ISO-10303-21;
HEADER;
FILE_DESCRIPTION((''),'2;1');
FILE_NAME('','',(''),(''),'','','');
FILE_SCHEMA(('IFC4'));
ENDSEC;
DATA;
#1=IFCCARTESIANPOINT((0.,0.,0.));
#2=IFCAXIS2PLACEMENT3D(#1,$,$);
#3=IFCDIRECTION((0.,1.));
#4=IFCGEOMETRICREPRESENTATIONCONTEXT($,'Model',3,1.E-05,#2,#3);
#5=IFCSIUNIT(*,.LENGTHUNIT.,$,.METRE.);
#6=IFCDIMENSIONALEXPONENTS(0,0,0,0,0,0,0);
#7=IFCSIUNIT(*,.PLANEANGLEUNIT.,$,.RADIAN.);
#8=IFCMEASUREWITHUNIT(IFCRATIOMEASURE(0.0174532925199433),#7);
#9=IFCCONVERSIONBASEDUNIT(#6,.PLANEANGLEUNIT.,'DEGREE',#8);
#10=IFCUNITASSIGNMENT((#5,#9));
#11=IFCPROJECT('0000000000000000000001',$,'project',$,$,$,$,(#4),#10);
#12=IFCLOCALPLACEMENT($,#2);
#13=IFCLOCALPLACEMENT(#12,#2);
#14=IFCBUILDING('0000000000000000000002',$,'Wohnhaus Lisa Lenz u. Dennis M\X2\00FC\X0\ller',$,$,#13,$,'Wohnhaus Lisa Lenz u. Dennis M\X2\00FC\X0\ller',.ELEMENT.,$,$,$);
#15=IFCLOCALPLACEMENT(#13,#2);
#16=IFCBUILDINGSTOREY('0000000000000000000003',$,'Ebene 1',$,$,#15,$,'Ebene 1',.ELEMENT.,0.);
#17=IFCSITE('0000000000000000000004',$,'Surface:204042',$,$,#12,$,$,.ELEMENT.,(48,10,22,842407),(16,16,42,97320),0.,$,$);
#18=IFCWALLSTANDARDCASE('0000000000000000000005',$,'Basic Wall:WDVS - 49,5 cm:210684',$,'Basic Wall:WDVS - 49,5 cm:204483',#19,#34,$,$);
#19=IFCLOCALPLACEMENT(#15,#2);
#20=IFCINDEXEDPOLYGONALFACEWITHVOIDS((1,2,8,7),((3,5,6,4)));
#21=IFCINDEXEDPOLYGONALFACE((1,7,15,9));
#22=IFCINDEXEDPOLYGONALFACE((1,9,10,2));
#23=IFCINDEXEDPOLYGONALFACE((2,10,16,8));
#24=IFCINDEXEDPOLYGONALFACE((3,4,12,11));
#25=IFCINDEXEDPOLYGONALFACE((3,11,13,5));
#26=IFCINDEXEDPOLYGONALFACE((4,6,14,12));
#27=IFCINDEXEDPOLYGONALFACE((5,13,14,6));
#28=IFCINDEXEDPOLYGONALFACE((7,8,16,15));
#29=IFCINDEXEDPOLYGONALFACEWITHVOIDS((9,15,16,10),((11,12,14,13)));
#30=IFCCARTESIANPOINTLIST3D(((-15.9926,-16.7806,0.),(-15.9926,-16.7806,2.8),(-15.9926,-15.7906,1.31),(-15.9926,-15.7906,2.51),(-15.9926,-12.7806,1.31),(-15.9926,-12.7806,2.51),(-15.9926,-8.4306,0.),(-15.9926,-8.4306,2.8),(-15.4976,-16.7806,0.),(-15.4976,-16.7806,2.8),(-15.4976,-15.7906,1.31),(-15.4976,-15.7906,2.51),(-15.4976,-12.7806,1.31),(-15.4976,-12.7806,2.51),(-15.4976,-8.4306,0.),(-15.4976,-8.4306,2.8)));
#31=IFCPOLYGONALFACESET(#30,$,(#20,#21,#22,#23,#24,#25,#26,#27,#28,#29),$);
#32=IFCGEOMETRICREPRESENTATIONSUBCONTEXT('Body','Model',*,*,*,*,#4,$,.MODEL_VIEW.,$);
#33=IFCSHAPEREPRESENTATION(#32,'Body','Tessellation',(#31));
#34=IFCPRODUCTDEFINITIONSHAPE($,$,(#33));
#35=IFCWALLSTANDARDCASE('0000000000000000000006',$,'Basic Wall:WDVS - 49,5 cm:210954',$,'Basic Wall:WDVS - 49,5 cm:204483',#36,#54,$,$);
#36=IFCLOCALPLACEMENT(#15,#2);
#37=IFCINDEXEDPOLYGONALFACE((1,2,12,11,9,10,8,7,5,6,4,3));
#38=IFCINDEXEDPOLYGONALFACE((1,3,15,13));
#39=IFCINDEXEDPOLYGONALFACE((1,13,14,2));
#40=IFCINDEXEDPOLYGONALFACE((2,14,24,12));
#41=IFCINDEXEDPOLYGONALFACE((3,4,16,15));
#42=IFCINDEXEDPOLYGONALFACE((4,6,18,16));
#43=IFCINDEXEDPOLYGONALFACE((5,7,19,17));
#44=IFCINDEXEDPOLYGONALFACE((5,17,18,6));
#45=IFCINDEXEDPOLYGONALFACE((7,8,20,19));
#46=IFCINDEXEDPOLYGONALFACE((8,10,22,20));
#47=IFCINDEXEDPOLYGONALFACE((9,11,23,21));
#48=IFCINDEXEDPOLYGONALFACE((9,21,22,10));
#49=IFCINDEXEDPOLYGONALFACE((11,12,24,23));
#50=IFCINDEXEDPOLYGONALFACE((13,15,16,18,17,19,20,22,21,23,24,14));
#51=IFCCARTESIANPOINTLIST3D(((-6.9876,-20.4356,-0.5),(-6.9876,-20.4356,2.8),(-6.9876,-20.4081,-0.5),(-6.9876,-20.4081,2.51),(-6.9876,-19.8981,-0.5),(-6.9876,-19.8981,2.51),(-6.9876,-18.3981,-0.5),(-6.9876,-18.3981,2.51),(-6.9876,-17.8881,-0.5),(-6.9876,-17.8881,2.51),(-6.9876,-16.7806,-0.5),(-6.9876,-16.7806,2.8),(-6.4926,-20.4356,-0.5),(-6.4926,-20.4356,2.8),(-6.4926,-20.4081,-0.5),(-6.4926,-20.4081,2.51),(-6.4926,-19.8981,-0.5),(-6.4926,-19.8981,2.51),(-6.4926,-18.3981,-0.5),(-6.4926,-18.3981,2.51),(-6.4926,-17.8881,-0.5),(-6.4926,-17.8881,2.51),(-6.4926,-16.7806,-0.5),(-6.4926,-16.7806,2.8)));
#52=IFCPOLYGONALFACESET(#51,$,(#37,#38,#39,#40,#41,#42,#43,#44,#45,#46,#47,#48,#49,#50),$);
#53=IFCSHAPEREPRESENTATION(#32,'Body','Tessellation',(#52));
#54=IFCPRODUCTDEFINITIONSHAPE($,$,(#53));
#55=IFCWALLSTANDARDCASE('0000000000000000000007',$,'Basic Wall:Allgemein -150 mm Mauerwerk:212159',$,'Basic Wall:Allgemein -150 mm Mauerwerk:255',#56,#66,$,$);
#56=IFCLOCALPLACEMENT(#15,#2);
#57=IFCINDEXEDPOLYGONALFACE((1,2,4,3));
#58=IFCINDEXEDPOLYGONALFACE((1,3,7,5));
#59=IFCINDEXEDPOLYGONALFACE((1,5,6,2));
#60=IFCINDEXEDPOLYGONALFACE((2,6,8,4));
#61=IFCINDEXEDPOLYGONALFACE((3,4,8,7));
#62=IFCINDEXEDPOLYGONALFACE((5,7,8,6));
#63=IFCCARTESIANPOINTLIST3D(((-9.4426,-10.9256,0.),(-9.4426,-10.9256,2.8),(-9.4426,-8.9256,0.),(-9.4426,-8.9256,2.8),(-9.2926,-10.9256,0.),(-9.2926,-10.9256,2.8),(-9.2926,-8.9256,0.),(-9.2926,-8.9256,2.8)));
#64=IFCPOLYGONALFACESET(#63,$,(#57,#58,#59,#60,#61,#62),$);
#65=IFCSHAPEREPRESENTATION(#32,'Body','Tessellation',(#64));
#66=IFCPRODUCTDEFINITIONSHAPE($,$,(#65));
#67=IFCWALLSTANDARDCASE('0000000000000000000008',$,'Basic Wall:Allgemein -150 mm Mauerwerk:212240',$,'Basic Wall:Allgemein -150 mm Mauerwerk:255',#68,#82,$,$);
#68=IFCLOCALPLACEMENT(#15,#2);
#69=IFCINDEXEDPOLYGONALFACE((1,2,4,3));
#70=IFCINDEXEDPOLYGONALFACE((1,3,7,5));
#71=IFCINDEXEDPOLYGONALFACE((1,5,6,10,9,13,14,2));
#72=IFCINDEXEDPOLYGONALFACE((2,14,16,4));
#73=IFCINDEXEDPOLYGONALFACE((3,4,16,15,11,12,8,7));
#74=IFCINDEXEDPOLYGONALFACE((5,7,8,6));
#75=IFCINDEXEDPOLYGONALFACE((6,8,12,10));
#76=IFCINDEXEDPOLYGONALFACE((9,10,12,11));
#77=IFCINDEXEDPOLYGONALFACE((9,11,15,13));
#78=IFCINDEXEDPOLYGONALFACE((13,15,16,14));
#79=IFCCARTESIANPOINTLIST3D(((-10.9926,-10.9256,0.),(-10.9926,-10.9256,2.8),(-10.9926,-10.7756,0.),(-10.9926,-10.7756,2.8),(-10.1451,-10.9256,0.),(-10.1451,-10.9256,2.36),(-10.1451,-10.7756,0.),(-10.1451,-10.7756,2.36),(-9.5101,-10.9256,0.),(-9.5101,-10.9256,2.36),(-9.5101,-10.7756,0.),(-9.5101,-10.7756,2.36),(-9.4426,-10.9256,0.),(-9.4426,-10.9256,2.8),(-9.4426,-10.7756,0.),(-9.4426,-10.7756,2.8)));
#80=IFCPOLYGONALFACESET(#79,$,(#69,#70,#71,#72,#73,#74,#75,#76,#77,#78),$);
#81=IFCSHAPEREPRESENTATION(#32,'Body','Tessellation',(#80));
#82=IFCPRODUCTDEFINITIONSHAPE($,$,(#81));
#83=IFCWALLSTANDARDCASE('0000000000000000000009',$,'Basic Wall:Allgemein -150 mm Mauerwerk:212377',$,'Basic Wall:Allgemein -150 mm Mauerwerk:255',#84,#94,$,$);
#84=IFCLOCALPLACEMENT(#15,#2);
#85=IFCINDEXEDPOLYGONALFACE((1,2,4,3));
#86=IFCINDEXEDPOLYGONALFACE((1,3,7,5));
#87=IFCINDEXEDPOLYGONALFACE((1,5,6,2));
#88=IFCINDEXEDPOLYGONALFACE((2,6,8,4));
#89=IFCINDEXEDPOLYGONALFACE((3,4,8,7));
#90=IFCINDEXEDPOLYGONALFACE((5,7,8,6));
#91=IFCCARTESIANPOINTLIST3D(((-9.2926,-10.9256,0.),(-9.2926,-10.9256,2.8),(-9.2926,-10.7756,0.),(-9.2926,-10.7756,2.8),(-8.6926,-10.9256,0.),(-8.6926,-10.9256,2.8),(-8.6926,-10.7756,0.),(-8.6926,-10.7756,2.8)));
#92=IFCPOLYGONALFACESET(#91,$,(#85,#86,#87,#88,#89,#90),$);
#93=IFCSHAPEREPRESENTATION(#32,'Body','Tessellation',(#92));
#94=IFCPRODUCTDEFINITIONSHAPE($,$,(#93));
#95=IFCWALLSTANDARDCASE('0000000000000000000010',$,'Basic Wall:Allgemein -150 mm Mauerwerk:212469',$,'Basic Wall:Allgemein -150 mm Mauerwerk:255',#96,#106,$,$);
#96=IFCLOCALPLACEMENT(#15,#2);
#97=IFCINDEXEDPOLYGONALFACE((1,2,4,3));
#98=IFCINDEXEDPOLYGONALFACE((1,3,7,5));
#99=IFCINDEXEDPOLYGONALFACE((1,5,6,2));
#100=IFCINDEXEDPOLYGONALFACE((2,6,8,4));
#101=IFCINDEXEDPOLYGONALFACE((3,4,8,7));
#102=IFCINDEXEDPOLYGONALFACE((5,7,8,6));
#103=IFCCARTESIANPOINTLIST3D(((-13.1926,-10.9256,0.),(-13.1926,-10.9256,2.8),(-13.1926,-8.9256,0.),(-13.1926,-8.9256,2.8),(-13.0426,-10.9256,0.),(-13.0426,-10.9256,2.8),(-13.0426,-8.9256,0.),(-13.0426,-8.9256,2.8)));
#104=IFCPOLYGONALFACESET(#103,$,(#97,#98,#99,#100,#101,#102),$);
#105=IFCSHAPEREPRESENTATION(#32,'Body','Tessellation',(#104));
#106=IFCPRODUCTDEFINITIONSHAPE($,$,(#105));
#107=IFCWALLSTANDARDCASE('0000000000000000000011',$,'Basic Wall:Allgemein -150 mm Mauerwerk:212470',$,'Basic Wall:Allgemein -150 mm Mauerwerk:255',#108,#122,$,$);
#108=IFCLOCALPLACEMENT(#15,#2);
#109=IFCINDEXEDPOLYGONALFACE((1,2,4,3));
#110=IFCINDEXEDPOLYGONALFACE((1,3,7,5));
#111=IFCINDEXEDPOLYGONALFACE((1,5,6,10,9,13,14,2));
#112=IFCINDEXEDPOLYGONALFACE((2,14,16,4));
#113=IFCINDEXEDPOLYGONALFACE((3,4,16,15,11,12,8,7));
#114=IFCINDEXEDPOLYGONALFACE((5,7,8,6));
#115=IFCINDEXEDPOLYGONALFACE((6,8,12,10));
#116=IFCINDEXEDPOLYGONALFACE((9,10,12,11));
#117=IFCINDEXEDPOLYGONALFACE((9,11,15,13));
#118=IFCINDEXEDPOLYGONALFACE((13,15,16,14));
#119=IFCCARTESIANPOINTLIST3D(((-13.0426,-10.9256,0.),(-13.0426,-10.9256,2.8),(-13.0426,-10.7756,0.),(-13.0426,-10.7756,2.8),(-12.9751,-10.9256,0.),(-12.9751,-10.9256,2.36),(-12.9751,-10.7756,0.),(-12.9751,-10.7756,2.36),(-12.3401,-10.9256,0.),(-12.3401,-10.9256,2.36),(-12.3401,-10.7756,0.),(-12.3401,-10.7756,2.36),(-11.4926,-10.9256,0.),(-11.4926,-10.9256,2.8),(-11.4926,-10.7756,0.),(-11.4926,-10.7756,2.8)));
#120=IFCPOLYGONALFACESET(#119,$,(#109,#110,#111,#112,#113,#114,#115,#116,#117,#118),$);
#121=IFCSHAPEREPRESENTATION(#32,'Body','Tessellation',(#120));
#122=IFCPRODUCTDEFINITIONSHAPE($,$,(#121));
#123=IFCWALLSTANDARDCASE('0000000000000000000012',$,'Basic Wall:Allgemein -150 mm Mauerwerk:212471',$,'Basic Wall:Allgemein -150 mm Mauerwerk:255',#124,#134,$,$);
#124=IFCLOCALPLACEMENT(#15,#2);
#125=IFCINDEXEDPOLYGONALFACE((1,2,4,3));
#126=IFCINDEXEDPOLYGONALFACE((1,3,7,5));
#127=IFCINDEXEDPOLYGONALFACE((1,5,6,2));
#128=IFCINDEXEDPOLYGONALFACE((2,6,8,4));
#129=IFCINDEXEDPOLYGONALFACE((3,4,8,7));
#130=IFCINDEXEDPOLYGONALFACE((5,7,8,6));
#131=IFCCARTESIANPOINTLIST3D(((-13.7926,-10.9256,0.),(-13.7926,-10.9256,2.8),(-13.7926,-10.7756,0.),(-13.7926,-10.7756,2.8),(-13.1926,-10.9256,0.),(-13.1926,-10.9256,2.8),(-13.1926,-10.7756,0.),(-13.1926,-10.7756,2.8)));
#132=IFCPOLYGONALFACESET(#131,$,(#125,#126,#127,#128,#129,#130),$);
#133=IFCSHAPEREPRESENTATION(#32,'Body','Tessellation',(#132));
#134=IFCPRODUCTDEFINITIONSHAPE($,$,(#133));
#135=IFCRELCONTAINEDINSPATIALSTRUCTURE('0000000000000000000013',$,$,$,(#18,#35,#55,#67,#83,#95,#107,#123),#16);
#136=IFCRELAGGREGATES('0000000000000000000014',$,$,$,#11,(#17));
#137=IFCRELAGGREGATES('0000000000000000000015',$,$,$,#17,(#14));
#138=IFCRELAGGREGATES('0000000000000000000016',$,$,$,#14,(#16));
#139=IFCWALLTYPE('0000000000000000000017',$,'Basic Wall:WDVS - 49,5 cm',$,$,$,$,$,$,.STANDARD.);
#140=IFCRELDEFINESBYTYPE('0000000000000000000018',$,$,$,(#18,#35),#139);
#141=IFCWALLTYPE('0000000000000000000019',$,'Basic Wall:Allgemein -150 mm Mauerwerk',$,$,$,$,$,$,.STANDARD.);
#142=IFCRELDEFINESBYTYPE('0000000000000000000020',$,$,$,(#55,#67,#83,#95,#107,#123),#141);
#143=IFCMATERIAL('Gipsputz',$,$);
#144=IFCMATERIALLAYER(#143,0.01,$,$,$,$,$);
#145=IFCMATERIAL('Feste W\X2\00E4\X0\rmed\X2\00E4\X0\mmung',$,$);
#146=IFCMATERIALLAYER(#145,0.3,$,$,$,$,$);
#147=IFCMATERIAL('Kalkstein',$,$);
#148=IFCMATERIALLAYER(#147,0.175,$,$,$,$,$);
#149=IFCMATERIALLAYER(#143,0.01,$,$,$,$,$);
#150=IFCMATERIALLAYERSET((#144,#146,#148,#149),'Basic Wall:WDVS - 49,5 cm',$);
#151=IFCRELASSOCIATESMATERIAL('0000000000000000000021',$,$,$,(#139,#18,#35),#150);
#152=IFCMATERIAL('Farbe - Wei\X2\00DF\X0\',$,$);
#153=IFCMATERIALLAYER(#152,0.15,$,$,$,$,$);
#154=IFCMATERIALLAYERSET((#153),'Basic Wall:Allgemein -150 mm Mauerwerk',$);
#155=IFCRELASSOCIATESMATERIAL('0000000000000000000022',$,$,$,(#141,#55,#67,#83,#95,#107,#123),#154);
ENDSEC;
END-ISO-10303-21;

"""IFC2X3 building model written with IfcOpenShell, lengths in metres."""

from ifc_helpers import new_model, entity, si_unit, converted_unit, direction, frame, frame_2d, origin, place, context, subcontext, project, spatial, polyline, rectangle, extrude, clip, bounded_halfspace, material, layer, layer_set, layer_usage, type_object, element, save


model = new_model("IFC2X3")

# Units and contexts
model_context = context("Model", 3, precision=1e-05, world=origin(), true_north=direction((0.0, 1.0)))
body_context = subcontext(model_context, "Body", "Model", "MODEL_VIEW")
ifc_project = project(units=[si_unit("LENGTHUNIT", "METRE"), converted_unit("PLANEANGLEUNIT", "DEGREE", entity("IfcRatioMeasure", 0.0174532925199433), si_unit("PLANEANGLEUNIT", "RADIAN"), dimensions=[0, 0, 0, 0, 0, 0, 0])], contexts=[model_context])

# Site, building, storey
site_placement = place(None, origin())
site = spatial("IfcSite", under=ifc_project, at=site_placement, Name="Surface:204042", CompositionType="ELEMENT", RefLatitude=(48, 10, 22, 842407), RefLongitude=(16, 16, 42, 97320), RefElevation=0.0)
building_placement = place(site_placement, origin())
building = spatial("IfcBuilding", under=site, at=building_placement, Name="Wohnhaus Lisa Lenz u. Dennis Müller", LongName="Wohnhaus Lisa Lenz u. Dennis Müller", CompositionType="ELEMENT")
storey_placement = place(building_placement, origin())
storey = spatial("IfcBuildingStorey", under=building, at=storey_placement, Name="Ebene 1", LongName="Ebene 1", CompositionType="ELEMENT", Elevation=0.0)

# Shared definitions
ifc_material_1 = material(Name="Gipsputz")
ifc_layer_1 = layer(ifc_material_1, 0.01)
ifc_material_2 = material(Name="Feste Wärmedämmung")
ifc_layer_2 = layer(ifc_material_2, 0.3)
ifc_material_3 = material(Name="Kalkstein")
ifc_layer_3 = layer(ifc_material_3, 0.175)
ifc_layer_4 = layer(ifc_material_1, 0.01)
ifc_layer_set_1 = layer_set([ifc_layer_1, ifc_layer_2, ifc_layer_3, ifc_layer_4], Name="Basic Wall:WDVS - 49,5 cm")
wall_type_1 = type_object("IfcWallType", Name="Basic Wall:WDVS - 49,5 cm", PredefinedType="STANDARD", material=ifc_layer_set_1)

# Wall, opening
ifc_layer_usage_1 = layer_usage(ifc_layer_set_1, "AXIS2", "NEGATIVE", 0.2475)
wall_1_placement = place(storey_placement, frame((-15.7451, -16.7806, 0.0), z_axis=(0.0, 0.0, 1.0), x_axis=(0.0, 1.0, 0.0)))
wall_1 = element("IfcWallStandardCase", 1, at=wall_1_placement, inside=storey, type_object=wall_type_1, material=ifc_layer_usage_1, Name="Basic Wall:WDVS - 49,5 cm:210684", ObjectType="Basic Wall:WDVS - 49,5 cm:204483", context=body_context, shape_type="Clipping", body=[
    clip(extrude(rectangle(XDim=8.35, YDim=0.495, at=frame_2d((4.175, 0.0), x_axis=(-1.0, 0.0))), origin(), (0.0, 0.0, 1.0), 2.8), bounded_halfspace(frame((0.0, -0.2475, 2.8), z_axis=(0.0, 0.0, -1.0), x_axis=(0.0, 1.0, 0.0)), True, frame((0.0, -0.2475, 2.8)), polyline([(0.0, 0.0), (7.855, 0.0), (8.35, 0.0), (8.35, 0.495), (0.0, 0.495), (0.0, 0.0)]))),
])
opening_1_placement = place(wall_1_placement, frame((4.0, 0.2475, 1.31)))
element("IfcOpeningElement", 2, at=opening_1_placement, cuts=wall_1, ObjectType="Opening", context=body_context, shape_type="SweptSolid", body=[
    extrude(rectangle(XDim=1.2, YDim=3.01, at=frame_2d((0.6, 1.505), x_axis=(1.0, 0.0))), frame((0.0, 0.0, 0.0), z_axis=(0.0, -1.0, 0.0), x_axis=(0.0, 0.0, 1.0)), (0.0, 0.0, 1.0), 0.495),
])

# Wall, openings
ifc_layer_usage_2 = layer_usage(ifc_layer_set_1, "AXIS2", "NEGATIVE", 0.2475)
wall_2_placement = place(storey_placement, frame((-6.7401, -16.7056, -0.5), z_axis=(0.0, 0.0, 1.0), x_axis=(0.0, -1.0, 0.0)))
wall_2 = element("IfcWallStandardCase", 3, at=wall_2_placement, inside=storey, type_object=wall_type_1, material=ifc_layer_usage_2, Name="Basic Wall:WDVS - 49,5 cm:210954", ObjectType="Basic Wall:WDVS - 49,5 cm:204483", context=body_context, shape_type="Clipping", body=[
    clip(extrude(rectangle(XDim=3.655, YDim=0.495, at=frame_2d((1.9025, 0.0), x_axis=(1.0, 0.0))), origin(), (0.0, 0.0, 1.0), 3.3), bounded_halfspace(frame((0.075, -0.2475, 3.3), z_axis=(0.0, 0.0, -1.0), x_axis=(0.0, -1.0, 0.0)), True, frame((0.075, -0.2475, 3.3)), polyline([(0.0, 0.0), (3.655, 0.0), (3.655, 0.495), (0.0, 0.495), (0.0, 0.0)]))),
])
opening_2_placement = place(wall_2_placement, frame((3.7025, 0.2475, 0.0)))
element("IfcOpeningElement", 4, at=opening_2_placement, cuts=wall_2, ObjectType="Opening", context=body_context, shape_type="SweptSolid", body=[
    extrude(rectangle(XDim=3.01, YDim=0.51, at=frame_2d((1.505, 0.255), x_axis=(1.0, 0.0))), frame((0.0, 0.0, 0.0), z_axis=(0.0, -1.0, 0.0), x_axis=(0.0, 0.0, 1.0)), (0.0, 0.0, 1.0), 0.495),
])
opening_3_placement = place(wall_2_placement, frame((1.6925, 0.2475, 0.0)))
element("IfcOpeningElement", 5, at=opening_3_placement, cuts=wall_2, ObjectType="Opening", context=body_context, shape_type="SweptSolid", body=[
    extrude(rectangle(XDim=3.01, YDim=0.51, at=frame_2d((1.505, 0.255), x_axis=(1.0, 0.0))), frame((0.0, 0.0, 0.0), z_axis=(0.0, -1.0, 0.0), x_axis=(0.0, 0.0, 1.0)), (0.0, 0.0, 1.0), 0.495),
])

# Wall
ifc_material_4 = material(Name="Farbe - Weiß")
ifc_layer_5 = layer(ifc_material_4, 0.15)
ifc_layer_set_2 = layer_set([ifc_layer_5], Name="Basic Wall:Allgemein -150 mm Mauerwerk")
ifc_layer_usage_3 = layer_usage(ifc_layer_set_2, "AXIS2", "NEGATIVE", 0.075)
wall_type_2 = type_object("IfcWallType", Name="Basic Wall:Allgemein -150 mm Mauerwerk", PredefinedType="STANDARD", material=ifc_layer_set_2)
wall_3_placement = place(storey_placement, frame((-9.3676, -8.9256, 0.0), z_axis=(0.0, 0.0, 1.0), x_axis=(0.0, -1.0, 0.0)))
element("IfcWallStandardCase", 6, at=wall_3_placement, inside=storey, type_object=wall_type_2, material=ifc_layer_usage_3, Name="Basic Wall:Allgemein -150 mm Mauerwerk:212159", ObjectType="Basic Wall:Allgemein -150 mm Mauerwerk:255", context=body_context, shape_type="Clipping", body=[
    clip(extrude(rectangle(XDim=2.0, YDim=0.15, at=frame_2d((1.0, 0.0), x_axis=(-1.0, 0.0))), origin(), (0.0, 0.0, 1.0), 2.8), bounded_halfspace(frame((0.0, -0.075, 2.8), z_axis=(0.0, 0.0, -1.0), x_axis=(0.0, -1.0, 0.0)), True, frame((0.0, -0.075, 2.8)), polyline([(0.0, 0.0), (1.85, 0.0), (2.0, 0.0), (2.0, 0.15), (1.85, 0.15), (0.0, 0.15), (0.0, 0.0)]))),
])

# Wall, opening
ifc_layer_usage_4 = layer_usage(ifc_layer_set_2, "AXIS2", "NEGATIVE", 0.075)
wall_4_placement = place(storey_placement, frame((-9.4426, -10.8506, 0.0), z_axis=(0.0, 0.0, 1.0), x_axis=(-1.0, 0.0, 0.0)))
wall_4 = element("IfcWallStandardCase", 7, at=wall_4_placement, inside=storey, type_object=wall_type_2, material=ifc_layer_usage_4, Name="Basic Wall:Allgemein -150 mm Mauerwerk:212240", ObjectType="Basic Wall:Allgemein -150 mm Mauerwerk:255", context=body_context, shape_type="Clipping", body=[
    clip(extrude(rectangle(XDim=1.55, YDim=0.15, at=frame_2d((0.775, 0.0), x_axis=(-1.0, 0.0))), origin(), (0.0, 0.0, 1.0), 2.8), bounded_halfspace(frame((0.0, -0.075, 2.8), z_axis=(0.0, 0.0, -1.0), x_axis=(1.0, 0.0, 0.0)), True, frame((0.0, -0.075, 2.8)), polyline([(0.0, 0.0), (1.55, 0.0), (1.55, 0.15), (0.0, 0.15), (0.0, 0.0)]))),
])
opening_4_placement = place(wall_4_placement, frame((0.7025, 0.075, 0.0)))
element("IfcOpeningElement", 8, at=opening_4_placement, cuts=wall_4, ObjectType="Opening", context=body_context, shape_type="SweptSolid", body=[
    extrude(rectangle(XDim=2.36, YDim=0.635, at=frame_2d((1.18, 0.3175), x_axis=(1.0, 0.0))), frame((0.0, 0.0, 0.0), z_axis=(0.0, -1.0, 0.0), x_axis=(0.0, 0.0, 1.0)), (0.0, 0.0, 1.0), 0.15),
])

# Walls
ifc_layer_usage_5 = layer_usage(ifc_layer_set_2, "AXIS2", "NEGATIVE", 0.075)
wall_5_placement = place(storey_placement, frame((-9.2926, -10.8506, 0.0)))
element("IfcWallStandardCase", 9, at=wall_5_placement, inside=storey, type_object=wall_type_2, material=ifc_layer_usage_5, Name="Basic Wall:Allgemein -150 mm Mauerwerk:212377", ObjectType="Basic Wall:Allgemein -150 mm Mauerwerk:255", context=body_context, shape_type="Clipping", body=[
    clip(extrude(rectangle(XDim=0.6, YDim=0.15, at=frame_2d((0.3, 0.0), x_axis=(-1.0, 0.0))), origin(), (0.0, 0.0, 1.0), 2.8), bounded_halfspace(frame((0.0, -0.075, 2.8), z_axis=(0.0, 0.0, -1.0), x_axis=(-1.0, 0.0, 0.0)), True, frame((0.0, -0.075, 2.8)), polyline([(0.0, 0.0), (0.6, 0.0), (0.6, 0.15), (0.0, 0.15), (0.0, 0.0)]))),
])
ifc_layer_usage_6 = layer_usage(ifc_layer_set_2, "AXIS2", "POSITIVE", -0.075)
wall_6_placement = place(storey_placement, frame((-13.1176, -8.9256, 0.0), z_axis=(0.0, 0.0, 1.0), x_axis=(0.0, -1.0, 0.0)))
element("IfcWallStandardCase", 10, at=wall_6_placement, inside=storey, type_object=wall_type_2, material=ifc_layer_usage_6, Name="Basic Wall:Allgemein -150 mm Mauerwerk:212469", ObjectType="Basic Wall:Allgemein -150 mm Mauerwerk:255", context=body_context, shape_type="Clipping", body=[
    clip(extrude(rectangle(XDim=2.0, YDim=0.15, at=frame_2d((1.0, 0.0), x_axis=(-1.0, 0.0))), origin(), (0.0, 0.0, 1.0), 2.8), bounded_halfspace(frame((0.0, -0.075, 2.8), z_axis=(0.0, 0.0, -1.0), x_axis=(0.0, -1.0, 0.0)), True, frame((0.0, -0.075, 2.8)), polyline([(0.0, 0.0), (1.85, 0.0), (2.0, 0.0), (2.0, 0.15), (1.85, 0.15), (0.0, 0.15), (0.0, 0.0)]))),
])

# Wall, opening
ifc_layer_usage_7 = layer_usage(ifc_layer_set_2, "AXIS2", "POSITIVE", -0.075)
wall_7_placement = place(storey_placement, frame((-13.0426, -10.8506, 0.0)))
wall_7 = element("IfcWallStandardCase", 11, at=wall_7_placement, inside=storey, type_object=wall_type_2, material=ifc_layer_usage_7, Name="Basic Wall:Allgemein -150 mm Mauerwerk:212470", ObjectType="Basic Wall:Allgemein -150 mm Mauerwerk:255", context=body_context, shape_type="Clipping", body=[
    clip(extrude(rectangle(XDim=1.55, YDim=0.15, at=frame_2d((0.775, 0.0), x_axis=(-1.0, 0.0))), origin(), (0.0, 0.0, 1.0), 2.8), bounded_halfspace(frame((0.0, -0.075, 2.8), z_axis=(0.0, 0.0, -1.0), x_axis=(-1.0, 0.0, 0.0)), True, frame((0.0, -0.075, 2.8)), polyline([(0.0, 0.0), (1.55, 0.0), (1.55, 0.15), (0.0, 0.15), (0.0, 0.0)]))),
])
opening_5_placement = place(wall_7_placement, frame((0.0675, -0.075, 0.0)))
element("IfcOpeningElement", 12, at=opening_5_placement, cuts=wall_7, ObjectType="Opening", context=body_context, shape_type="SweptSolid", body=[
    extrude(rectangle(XDim=2.36, YDim=0.635, at=frame_2d((1.18, 0.3175), x_axis=(1.0, 0.0))), frame((0.0, 0.0, 0.0), z_axis=(0.0, 1.0, 0.0), x_axis=(0.0, 0.0, 1.0)), (0.0, 0.0, 1.0), 0.15),
])

# Wall
ifc_layer_usage_8 = layer_usage(ifc_layer_set_2, "AXIS2", "POSITIVE", -0.075)
wall_8_placement = place(storey_placement, frame((-13.1926, -10.8506, 0.0), z_axis=(0.0, 0.0, 1.0), x_axis=(-1.0, 0.0, 0.0)))
element("IfcWallStandardCase", 13, at=wall_8_placement, inside=storey, type_object=wall_type_2, material=ifc_layer_usage_8, Name="Basic Wall:Allgemein -150 mm Mauerwerk:212471", ObjectType="Basic Wall:Allgemein -150 mm Mauerwerk:255", context=body_context, shape_type="Clipping", body=[
    clip(extrude(rectangle(XDim=0.6, YDim=0.15, at=frame_2d((0.3, 0.0), x_axis=(-1.0, 0.0))), origin(), (0.0, 0.0, 1.0), 2.8), bounded_halfspace(frame((0.0, -0.075, 2.8), z_axis=(0.0, 0.0, -1.0), x_axis=(1.0, 0.0, 0.0)), True, frame((0.0, -0.075, 2.8)), polyline([(0.0, 0.0), (0.6, 0.0), (0.6, 0.15), (0.0, 0.15), (0.0, 0.0)]))),
])

save(model, "model.ifc")
